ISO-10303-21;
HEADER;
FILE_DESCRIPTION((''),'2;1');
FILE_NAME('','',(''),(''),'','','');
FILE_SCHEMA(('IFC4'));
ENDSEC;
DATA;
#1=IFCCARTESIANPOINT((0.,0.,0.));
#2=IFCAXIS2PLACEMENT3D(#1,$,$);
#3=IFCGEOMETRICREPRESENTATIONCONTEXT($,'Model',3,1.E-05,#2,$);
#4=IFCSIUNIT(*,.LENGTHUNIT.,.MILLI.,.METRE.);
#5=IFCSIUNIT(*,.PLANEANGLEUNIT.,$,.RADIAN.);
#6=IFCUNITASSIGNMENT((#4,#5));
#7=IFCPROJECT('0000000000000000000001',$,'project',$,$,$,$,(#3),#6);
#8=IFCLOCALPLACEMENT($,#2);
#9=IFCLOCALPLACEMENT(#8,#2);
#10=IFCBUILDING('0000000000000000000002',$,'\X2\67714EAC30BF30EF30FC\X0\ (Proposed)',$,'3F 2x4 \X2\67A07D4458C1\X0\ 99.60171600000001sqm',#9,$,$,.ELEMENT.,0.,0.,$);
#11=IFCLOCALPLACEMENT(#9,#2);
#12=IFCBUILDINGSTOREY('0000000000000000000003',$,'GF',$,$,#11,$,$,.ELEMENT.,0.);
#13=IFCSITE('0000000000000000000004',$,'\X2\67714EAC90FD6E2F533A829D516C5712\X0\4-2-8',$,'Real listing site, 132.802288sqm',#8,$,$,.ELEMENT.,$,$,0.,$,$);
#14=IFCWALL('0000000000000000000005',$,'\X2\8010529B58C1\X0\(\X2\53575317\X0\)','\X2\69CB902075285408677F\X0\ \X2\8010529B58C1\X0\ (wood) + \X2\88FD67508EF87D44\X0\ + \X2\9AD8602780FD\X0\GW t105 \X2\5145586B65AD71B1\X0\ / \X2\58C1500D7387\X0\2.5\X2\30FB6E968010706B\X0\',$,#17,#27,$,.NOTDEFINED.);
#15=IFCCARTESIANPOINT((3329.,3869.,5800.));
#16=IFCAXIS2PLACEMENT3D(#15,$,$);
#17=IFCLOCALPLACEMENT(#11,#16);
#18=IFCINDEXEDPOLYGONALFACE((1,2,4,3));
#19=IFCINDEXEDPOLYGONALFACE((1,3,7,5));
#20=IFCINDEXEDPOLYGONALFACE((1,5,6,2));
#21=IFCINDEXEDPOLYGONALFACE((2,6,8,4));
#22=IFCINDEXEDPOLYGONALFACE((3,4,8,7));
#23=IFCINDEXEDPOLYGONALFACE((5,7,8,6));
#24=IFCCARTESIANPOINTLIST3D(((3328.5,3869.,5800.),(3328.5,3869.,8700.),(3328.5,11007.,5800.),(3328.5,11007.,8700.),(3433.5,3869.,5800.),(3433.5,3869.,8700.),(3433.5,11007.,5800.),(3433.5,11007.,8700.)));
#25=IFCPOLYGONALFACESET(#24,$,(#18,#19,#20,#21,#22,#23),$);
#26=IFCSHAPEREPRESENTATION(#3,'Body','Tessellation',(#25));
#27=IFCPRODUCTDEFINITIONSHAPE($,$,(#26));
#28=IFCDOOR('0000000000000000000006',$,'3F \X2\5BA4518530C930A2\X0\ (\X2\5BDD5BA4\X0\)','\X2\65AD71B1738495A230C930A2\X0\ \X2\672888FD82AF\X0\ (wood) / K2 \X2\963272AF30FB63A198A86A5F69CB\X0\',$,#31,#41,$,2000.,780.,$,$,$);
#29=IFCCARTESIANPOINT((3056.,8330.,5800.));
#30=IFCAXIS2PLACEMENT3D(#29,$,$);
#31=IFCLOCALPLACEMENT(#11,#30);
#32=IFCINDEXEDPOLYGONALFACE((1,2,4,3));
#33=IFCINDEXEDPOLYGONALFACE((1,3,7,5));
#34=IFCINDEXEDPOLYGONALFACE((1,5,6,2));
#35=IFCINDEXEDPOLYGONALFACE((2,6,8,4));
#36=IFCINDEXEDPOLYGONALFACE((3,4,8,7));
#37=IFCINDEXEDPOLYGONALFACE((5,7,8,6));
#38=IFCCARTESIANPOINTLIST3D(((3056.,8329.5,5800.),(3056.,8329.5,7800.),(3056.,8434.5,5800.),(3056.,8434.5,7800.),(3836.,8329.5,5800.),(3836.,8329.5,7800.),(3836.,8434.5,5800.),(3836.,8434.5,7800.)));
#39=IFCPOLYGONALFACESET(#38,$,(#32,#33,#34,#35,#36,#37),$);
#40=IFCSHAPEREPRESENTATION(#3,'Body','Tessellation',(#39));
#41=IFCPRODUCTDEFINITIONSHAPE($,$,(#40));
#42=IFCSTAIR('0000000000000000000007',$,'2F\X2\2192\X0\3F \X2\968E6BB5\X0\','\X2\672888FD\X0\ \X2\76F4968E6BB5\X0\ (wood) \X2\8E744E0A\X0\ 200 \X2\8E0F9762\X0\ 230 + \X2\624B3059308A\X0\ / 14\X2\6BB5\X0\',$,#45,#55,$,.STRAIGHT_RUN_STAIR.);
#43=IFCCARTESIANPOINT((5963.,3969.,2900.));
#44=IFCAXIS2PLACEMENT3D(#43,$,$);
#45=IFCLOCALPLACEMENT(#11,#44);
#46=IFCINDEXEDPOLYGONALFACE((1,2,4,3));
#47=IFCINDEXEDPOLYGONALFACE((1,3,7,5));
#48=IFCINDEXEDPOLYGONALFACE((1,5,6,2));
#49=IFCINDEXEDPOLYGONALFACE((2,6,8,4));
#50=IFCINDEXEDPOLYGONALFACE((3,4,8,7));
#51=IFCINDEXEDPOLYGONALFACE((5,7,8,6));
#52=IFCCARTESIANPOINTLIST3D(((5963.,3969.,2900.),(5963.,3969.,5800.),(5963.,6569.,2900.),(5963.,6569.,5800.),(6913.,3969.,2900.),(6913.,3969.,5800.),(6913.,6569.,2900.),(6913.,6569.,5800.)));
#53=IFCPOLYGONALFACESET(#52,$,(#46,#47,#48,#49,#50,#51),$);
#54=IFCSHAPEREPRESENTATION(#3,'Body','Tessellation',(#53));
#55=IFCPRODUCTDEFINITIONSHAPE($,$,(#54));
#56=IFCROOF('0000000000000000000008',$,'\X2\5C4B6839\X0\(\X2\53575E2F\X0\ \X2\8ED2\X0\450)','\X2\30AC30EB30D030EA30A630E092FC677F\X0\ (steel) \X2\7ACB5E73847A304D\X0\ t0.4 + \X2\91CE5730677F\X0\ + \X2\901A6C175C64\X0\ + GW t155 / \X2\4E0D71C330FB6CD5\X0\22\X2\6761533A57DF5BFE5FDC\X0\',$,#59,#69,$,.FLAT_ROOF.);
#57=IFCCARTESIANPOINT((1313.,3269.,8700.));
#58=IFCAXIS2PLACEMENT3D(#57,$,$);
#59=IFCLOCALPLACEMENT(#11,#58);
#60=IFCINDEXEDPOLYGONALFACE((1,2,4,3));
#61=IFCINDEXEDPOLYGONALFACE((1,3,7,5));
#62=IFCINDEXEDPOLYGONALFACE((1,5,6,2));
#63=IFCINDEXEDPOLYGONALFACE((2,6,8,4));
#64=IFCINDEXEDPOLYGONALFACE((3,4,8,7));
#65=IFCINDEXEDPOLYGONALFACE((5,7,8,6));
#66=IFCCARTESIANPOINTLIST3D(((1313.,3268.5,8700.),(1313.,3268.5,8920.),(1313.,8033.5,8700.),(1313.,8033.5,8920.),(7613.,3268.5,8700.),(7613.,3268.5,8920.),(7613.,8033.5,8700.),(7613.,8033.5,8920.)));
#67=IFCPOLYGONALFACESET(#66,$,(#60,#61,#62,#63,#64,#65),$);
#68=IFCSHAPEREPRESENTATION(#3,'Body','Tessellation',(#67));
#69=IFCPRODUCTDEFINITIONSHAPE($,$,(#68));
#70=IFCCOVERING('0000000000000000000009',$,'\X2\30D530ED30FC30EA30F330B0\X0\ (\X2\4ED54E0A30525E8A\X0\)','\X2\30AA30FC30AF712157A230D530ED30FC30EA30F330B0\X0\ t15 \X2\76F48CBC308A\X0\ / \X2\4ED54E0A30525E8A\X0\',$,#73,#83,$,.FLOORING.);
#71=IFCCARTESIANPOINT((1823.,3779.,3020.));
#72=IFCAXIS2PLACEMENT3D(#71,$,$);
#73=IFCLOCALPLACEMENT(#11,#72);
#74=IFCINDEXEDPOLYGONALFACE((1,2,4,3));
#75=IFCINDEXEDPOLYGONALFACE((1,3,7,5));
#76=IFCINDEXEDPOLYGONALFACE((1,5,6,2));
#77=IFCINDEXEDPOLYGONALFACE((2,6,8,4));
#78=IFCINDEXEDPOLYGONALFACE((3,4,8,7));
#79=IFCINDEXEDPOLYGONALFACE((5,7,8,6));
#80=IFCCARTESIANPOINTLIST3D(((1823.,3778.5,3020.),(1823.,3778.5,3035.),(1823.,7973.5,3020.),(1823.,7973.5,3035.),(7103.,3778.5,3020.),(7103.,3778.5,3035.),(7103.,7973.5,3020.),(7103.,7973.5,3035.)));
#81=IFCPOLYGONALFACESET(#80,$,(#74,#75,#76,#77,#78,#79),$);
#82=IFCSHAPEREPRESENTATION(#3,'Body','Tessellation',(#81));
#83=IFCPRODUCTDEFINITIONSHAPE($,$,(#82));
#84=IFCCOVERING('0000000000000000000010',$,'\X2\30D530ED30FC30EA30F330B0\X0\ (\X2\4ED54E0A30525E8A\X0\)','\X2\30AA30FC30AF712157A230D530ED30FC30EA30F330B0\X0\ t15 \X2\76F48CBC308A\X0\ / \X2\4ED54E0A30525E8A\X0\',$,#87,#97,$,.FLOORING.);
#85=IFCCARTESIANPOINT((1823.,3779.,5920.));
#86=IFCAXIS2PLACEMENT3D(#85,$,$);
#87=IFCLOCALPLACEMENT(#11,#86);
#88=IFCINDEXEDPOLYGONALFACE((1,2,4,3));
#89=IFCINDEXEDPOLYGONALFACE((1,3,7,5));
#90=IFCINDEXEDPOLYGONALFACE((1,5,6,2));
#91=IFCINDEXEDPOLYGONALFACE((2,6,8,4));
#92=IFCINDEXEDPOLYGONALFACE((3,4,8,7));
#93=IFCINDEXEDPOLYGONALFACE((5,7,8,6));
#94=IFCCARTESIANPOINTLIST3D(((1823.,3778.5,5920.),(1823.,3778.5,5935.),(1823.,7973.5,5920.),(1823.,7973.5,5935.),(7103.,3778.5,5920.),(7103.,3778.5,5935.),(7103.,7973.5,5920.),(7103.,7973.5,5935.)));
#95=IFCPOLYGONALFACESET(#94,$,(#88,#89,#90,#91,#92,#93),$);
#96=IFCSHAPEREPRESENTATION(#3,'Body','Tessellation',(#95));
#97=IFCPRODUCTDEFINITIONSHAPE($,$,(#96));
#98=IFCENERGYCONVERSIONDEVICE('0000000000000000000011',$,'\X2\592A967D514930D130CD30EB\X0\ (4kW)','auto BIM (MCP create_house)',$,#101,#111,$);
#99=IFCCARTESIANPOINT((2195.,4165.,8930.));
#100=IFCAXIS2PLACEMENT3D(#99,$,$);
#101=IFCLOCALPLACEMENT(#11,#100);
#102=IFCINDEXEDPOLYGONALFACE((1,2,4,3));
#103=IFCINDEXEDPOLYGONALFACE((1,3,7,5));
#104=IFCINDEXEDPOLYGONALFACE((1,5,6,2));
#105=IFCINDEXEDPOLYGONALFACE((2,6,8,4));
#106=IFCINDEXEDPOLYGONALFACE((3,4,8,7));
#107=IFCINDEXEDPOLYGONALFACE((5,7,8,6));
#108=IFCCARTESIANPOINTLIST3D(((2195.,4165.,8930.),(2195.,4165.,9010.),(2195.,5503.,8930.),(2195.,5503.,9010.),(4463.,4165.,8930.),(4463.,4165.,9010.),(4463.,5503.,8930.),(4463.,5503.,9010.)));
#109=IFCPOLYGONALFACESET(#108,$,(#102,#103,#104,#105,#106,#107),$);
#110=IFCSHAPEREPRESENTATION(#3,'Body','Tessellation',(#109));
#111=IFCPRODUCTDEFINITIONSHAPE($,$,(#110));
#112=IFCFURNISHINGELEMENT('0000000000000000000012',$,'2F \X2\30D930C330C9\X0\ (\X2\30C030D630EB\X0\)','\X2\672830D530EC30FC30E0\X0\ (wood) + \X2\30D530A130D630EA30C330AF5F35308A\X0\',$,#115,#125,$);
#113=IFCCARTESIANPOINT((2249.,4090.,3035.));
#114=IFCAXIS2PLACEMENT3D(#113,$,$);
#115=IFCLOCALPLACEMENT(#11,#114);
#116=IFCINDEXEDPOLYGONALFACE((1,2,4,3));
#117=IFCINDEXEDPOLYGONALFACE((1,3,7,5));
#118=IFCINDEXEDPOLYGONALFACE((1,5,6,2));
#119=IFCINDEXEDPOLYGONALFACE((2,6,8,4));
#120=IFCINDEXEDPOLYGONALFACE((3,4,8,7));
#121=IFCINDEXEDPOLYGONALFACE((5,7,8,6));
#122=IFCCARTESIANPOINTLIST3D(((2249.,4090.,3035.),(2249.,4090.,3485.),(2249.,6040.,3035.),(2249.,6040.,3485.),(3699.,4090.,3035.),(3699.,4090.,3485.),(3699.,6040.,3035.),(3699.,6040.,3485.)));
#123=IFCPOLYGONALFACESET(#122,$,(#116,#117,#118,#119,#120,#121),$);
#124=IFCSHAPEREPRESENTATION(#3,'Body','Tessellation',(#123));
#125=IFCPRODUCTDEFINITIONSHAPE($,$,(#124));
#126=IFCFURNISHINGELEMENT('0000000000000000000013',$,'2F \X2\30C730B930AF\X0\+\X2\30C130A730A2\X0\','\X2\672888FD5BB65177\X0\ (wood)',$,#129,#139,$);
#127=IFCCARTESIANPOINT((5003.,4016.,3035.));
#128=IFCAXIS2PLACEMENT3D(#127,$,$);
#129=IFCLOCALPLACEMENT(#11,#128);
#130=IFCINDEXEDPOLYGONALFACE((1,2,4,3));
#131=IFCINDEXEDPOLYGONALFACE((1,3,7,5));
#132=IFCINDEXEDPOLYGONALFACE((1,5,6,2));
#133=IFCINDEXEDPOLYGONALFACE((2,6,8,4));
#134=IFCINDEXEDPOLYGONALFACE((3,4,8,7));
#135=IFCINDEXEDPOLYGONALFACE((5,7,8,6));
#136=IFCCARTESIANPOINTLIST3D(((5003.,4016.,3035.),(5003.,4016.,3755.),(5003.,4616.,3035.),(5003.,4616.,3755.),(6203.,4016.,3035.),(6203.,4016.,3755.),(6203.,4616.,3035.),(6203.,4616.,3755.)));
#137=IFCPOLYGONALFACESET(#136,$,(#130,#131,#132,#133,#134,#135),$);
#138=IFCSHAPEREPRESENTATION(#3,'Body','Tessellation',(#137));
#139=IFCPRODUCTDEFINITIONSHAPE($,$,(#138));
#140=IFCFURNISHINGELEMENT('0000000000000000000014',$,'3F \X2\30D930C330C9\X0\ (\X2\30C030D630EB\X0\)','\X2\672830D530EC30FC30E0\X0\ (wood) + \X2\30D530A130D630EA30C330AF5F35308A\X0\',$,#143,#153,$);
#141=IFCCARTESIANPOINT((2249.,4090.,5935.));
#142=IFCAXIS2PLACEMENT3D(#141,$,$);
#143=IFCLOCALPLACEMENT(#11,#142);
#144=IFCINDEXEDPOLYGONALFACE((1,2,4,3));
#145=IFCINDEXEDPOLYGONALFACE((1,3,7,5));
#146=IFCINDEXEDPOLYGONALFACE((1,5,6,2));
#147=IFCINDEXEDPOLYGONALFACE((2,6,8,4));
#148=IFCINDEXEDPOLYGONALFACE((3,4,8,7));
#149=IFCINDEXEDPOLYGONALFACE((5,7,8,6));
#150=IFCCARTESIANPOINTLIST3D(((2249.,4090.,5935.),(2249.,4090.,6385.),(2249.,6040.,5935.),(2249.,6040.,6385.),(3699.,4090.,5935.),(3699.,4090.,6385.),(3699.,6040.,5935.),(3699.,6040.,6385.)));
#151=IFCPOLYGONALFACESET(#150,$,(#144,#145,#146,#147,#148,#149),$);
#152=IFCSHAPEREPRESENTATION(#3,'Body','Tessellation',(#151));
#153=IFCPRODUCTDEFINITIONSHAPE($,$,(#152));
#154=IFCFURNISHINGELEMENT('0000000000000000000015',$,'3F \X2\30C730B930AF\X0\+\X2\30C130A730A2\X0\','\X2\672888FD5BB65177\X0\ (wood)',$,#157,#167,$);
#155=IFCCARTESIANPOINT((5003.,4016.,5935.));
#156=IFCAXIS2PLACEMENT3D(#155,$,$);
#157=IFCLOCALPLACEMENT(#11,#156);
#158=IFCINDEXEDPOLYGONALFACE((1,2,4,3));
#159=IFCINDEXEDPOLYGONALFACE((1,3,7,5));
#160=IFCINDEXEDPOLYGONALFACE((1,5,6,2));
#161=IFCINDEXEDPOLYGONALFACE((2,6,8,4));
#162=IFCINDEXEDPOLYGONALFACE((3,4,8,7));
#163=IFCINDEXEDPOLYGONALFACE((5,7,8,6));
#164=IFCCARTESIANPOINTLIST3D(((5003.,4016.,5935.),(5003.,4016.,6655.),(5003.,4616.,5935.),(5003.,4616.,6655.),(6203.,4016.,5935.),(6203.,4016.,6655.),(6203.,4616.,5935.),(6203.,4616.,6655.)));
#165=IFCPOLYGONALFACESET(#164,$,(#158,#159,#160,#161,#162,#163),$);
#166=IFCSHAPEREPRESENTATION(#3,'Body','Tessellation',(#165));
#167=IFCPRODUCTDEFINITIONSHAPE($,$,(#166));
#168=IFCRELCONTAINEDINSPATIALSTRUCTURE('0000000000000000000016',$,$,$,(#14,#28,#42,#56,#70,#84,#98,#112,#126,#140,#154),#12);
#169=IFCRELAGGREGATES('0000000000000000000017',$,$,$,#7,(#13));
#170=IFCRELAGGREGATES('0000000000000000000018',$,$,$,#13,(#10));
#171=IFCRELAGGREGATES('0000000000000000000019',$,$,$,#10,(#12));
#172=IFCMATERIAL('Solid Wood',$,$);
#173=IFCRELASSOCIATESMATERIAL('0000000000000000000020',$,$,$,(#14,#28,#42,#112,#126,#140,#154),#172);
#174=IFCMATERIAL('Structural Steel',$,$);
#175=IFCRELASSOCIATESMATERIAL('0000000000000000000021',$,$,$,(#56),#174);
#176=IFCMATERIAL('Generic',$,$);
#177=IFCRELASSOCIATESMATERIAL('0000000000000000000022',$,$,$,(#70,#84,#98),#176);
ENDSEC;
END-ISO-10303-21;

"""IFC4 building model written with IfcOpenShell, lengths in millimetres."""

from ifc_helpers import new_model, si_unit, frame, frame_2d, origin, place, context, project, spatial, rectangle, extrude, material, element, fill, save


model = new_model("IFC4")

# Units and contexts
model_context = context("Model", 3, precision=1e-05, world=origin())
ifc_project = project(units=[si_unit("LENGTHUNIT", "METRE", prefix="MILLI"), si_unit("PLANEANGLEUNIT", "RADIAN")], contexts=[model_context])

# Site, building, storey
site_placement = place(None, origin())
site = spatial("IfcSite", under=ifc_project, at=site_placement, Name="東京都港区芝公園4-2-8", ObjectType="Real listing site, 132.802288sqm", CompositionType="ELEMENT", RefElevation=0.0)
building_placement = place(site_placement, origin())
building = spatial("IfcBuilding", under=site, at=building_placement, Name="東京タワー (Proposed)", ObjectType="3F 2x4 枠組壁 99.60171600000001sqm", CompositionType="ELEMENT", ElevationOfRefHeight=0.0, ElevationOfTerrain=0.0)
storey_placement = place(building_placement, origin())
storey = spatial("IfcBuildingStorey", under=building, at=storey_placement, Name="GF", CompositionType="ELEMENT", Elevation=0.0)

# Shared definitions
ifc_material_1 = material(Name="Solid Wood")

# Wall, opening, door
wall_1_placement = place(storey_placement, frame((3329.0, 3869.0, 5800.0)))
wall_1 = element("IfcWall", 1, at=wall_1_placement, inside=storey, material=ifc_material_1, Name="耐力壁(南北)", Description="構造用合板 耐力壁 (wood) + 製材軸組 + 高性能GW t105 充填断熱 / 壁倍率2.5・準耐火", PredefinedType="NOTDEFINED", context=model_context, shape_type="SweptSolid", body=[
    extrude(rectangle(XDim=105.0, YDim=7138.0, at=frame_2d((52.0, 3569.0))), frame((3329.0, 3869.0, 5800.0)), (0.0, 0.0, 1.0), 2900.0),
])
opening_1_placement = place(storey_placement, frame((3056.0, 8330.0, 5800.0)))
opening_1 = element("IfcOpeningElement", 2, at=opening_1_placement, cuts=wall_1, PredefinedType="NOTDEFINED", context=model_context, shape_type="SweptSolid", body=[
    extrude(rectangle(XDim=780.0, YDim=105.0, at=frame_2d((390.0, 52.0))), frame((3056.0, 8330.0, 5800.0)), (0.0, 0.0, 1.0), 2000.0),
])
door_1_placement = place(storey_placement, frame((3056.0, 8330.0, 5800.0)))
door_1 = element("IfcDoor", 3, at=door_1_placement, inside=storey, material=ifc_material_1, Name="3F 室内ドア (寝室)", Description="断熱玄関ドア 木製芯 (wood) / K2 防犯・採風機構", OverallHeight=2000.0, OverallWidth=780.0, context=model_context, shape_type="SweptSolid", body=[
    extrude(rectangle(XDim=780.0, YDim=105.0, at=frame_2d((390.0, 52.0))), frame((3056.0, 8330.0, 5800.0)), (0.0, 0.0, 1.0), 2000.0),
])
fill(opening_1, door_1)

# Stair
stair_placement = place(storey_placement, frame((5963.0, 3969.0, 2900.0)))
element("IfcStair", 4, at=stair_placement, inside=storey, material=ifc_material_1, Name="2F→3F 階段", Description="木製 直階段 (wood) 蹴上 200 踏面 230 + 手すり / 14段", PredefinedType="STRAIGHT_RUN_STAIR", context=model_context, shape_type="SweptSolid", body=[
    extrude(rectangle(XDim=950.0, YDim=2600.0, at=frame_2d((475.0, 1300.0))), frame((5963.0, 3969.0, 2900.0)), (0.0, 0.0, 1.0), 2900.0),
])

# Roof
ifc_material_2 = material(Name="Structural Steel")
for number, where, name in (
    (5, (1313.0, 3269.0, 8700.0), "屋根(南帯 軒450)"),
):
    element("IfcRoof", number, at=place(storey_placement, frame(where)), inside=storey, material=ifc_material_2, Name=name, Description="ガルバリウム鋼板 (steel) 立平葺き t0.4 + 野地板 + 通気層 + GW t155 / 不燃・法22条区域対応", PredefinedType="FLAT_ROOF", context=model_context, shape_type="SweptSolid", body=[
        extrude(rectangle(XDim=6300.0, YDim=4765.0, at=frame_2d((3150.0, 2382.0))), frame((1313.0, 3269.0, 8700.0)), (0.0, 0.0, 1.0), 220.0),
    ])

# Coverings
ifc_material_3 = material(Name="Generic")
covering_1_placement = place(storey_placement, frame((1823.0, 3779.0, 3020.0)))
element("IfcCovering", 6, at=covering_1_placement, inside=storey, material=ifc_material_3, Name="フローリング (仕上げ床)", Description="オーク無垢フローリング t15 直貼り / 仕上げ床", PredefinedType="FLOORING", context=model_context, shape_type="SweptSolid", body=[
    extrude(rectangle(XDim=5280.0, YDim=4195.0, at=frame_2d((2640.0, 2097.0))), frame((1823.0, 3779.0, 3020.0)), (0.0, 0.0, 1.0), 15.0),
])
covering_2_placement = place(storey_placement, frame((1823.0, 3779.0, 5920.0)))
element("IfcCovering", 7, at=covering_2_placement, inside=storey, material=ifc_material_3, Name="フローリング (仕上げ床)", Description="オーク無垢フローリング t15 直貼り / 仕上げ床", PredefinedType="FLOORING", context=model_context, shape_type="SweptSolid", body=[
    extrude(rectangle(XDim=5280.0, YDim=4195.0, at=frame_2d((2640.0, 2097.0))), frame((1823.0, 3779.0, 5920.0)), (0.0, 0.0, 1.0), 15.0),
])

# Energy conversion device
energy_conversion_device_placement = place(storey_placement, frame((2195.0, 4165.0, 8930.0)))
element("IfcEnergyConversionDevice", 8, at=energy_conversion_device_placement, inside=storey, material=ifc_material_3, Name="太陽光パネル (4kW)", Description="auto BIM (MCP create_house)", context=model_context, shape_type="SweptSolid", body=[
    extrude(rectangle(XDim=2268.0, YDim=1338.0, at=frame_2d((1134.0, 669.0))), frame((2195.0, 4165.0, 8930.0)), (0.0, 0.0, 1.0), 80.0),
])

# Furnishing elements
furnishing_1_placement = place(storey_placement, frame((2249.0, 4090.0, 3035.0)))
element("IfcFurnishingElement", 9, at=furnishing_1_placement, inside=storey, material=ifc_material_1, Name="2F ベッド (ダブル)", Description="木フレーム (wood) + ファブリック張り", context=model_context, shape_type="SweptSolid", body=[
    extrude(rectangle(XDim=1450.0, YDim=1950.0, at=frame_2d((725.0, 975.0))), frame((2249.0, 4090.0, 3035.0)), (0.0, 0.0, 1.0), 450.0),
])
furnishing_2_placement = place(storey_placement, frame((5003.0, 4016.0, 3035.0)))
element("IfcFurnishingElement", 10, at=furnishing_2_placement, inside=storey, material=ifc_material_1, Name="2F デスク+チェア", Description="木製家具 (wood)", context=model_context, shape_type="SweptSolid", body=[
    extrude(rectangle(XDim=1200.0, YDim=600.0, at=frame_2d((600.0, 300.0))), frame((5003.0, 4016.0, 3035.0)), (0.0, 0.0, 1.0), 720.0),
])
furnishing_3_placement = place(storey_placement, frame((2249.0, 4090.0, 5935.0)))
element("IfcFurnishingElement", 11, at=furnishing_3_placement, inside=storey, material=ifc_material_1, Name="3F ベッド (ダブル)", Description="木フレーム (wood) + ファブリック張り", context=model_context, shape_type="SweptSolid", body=[
    extrude(rectangle(XDim=1450.0, YDim=1950.0, at=frame_2d((725.0, 975.0))), frame((2249.0, 4090.0, 5935.0)), (0.0, 0.0, 1.0), 450.0),
])
furnishing_4_placement = place(storey_placement, frame((5003.0, 4016.0, 5935.0)))
element("IfcFurnishingElement", 12, at=furnishing_4_placement, inside=storey, material=ifc_material_1, Name="3F デスク+チェア", Description="木製家具 (wood)", context=model_context, shape_type="SweptSolid", body=[
    extrude(rectangle(XDim=1200.0, YDim=600.0, at=frame_2d((600.0, 300.0))), frame((5003.0, 4016.0, 5935.0)), (0.0, 0.0, 1.0), 720.0),
])

save(model, "model.ifc")
